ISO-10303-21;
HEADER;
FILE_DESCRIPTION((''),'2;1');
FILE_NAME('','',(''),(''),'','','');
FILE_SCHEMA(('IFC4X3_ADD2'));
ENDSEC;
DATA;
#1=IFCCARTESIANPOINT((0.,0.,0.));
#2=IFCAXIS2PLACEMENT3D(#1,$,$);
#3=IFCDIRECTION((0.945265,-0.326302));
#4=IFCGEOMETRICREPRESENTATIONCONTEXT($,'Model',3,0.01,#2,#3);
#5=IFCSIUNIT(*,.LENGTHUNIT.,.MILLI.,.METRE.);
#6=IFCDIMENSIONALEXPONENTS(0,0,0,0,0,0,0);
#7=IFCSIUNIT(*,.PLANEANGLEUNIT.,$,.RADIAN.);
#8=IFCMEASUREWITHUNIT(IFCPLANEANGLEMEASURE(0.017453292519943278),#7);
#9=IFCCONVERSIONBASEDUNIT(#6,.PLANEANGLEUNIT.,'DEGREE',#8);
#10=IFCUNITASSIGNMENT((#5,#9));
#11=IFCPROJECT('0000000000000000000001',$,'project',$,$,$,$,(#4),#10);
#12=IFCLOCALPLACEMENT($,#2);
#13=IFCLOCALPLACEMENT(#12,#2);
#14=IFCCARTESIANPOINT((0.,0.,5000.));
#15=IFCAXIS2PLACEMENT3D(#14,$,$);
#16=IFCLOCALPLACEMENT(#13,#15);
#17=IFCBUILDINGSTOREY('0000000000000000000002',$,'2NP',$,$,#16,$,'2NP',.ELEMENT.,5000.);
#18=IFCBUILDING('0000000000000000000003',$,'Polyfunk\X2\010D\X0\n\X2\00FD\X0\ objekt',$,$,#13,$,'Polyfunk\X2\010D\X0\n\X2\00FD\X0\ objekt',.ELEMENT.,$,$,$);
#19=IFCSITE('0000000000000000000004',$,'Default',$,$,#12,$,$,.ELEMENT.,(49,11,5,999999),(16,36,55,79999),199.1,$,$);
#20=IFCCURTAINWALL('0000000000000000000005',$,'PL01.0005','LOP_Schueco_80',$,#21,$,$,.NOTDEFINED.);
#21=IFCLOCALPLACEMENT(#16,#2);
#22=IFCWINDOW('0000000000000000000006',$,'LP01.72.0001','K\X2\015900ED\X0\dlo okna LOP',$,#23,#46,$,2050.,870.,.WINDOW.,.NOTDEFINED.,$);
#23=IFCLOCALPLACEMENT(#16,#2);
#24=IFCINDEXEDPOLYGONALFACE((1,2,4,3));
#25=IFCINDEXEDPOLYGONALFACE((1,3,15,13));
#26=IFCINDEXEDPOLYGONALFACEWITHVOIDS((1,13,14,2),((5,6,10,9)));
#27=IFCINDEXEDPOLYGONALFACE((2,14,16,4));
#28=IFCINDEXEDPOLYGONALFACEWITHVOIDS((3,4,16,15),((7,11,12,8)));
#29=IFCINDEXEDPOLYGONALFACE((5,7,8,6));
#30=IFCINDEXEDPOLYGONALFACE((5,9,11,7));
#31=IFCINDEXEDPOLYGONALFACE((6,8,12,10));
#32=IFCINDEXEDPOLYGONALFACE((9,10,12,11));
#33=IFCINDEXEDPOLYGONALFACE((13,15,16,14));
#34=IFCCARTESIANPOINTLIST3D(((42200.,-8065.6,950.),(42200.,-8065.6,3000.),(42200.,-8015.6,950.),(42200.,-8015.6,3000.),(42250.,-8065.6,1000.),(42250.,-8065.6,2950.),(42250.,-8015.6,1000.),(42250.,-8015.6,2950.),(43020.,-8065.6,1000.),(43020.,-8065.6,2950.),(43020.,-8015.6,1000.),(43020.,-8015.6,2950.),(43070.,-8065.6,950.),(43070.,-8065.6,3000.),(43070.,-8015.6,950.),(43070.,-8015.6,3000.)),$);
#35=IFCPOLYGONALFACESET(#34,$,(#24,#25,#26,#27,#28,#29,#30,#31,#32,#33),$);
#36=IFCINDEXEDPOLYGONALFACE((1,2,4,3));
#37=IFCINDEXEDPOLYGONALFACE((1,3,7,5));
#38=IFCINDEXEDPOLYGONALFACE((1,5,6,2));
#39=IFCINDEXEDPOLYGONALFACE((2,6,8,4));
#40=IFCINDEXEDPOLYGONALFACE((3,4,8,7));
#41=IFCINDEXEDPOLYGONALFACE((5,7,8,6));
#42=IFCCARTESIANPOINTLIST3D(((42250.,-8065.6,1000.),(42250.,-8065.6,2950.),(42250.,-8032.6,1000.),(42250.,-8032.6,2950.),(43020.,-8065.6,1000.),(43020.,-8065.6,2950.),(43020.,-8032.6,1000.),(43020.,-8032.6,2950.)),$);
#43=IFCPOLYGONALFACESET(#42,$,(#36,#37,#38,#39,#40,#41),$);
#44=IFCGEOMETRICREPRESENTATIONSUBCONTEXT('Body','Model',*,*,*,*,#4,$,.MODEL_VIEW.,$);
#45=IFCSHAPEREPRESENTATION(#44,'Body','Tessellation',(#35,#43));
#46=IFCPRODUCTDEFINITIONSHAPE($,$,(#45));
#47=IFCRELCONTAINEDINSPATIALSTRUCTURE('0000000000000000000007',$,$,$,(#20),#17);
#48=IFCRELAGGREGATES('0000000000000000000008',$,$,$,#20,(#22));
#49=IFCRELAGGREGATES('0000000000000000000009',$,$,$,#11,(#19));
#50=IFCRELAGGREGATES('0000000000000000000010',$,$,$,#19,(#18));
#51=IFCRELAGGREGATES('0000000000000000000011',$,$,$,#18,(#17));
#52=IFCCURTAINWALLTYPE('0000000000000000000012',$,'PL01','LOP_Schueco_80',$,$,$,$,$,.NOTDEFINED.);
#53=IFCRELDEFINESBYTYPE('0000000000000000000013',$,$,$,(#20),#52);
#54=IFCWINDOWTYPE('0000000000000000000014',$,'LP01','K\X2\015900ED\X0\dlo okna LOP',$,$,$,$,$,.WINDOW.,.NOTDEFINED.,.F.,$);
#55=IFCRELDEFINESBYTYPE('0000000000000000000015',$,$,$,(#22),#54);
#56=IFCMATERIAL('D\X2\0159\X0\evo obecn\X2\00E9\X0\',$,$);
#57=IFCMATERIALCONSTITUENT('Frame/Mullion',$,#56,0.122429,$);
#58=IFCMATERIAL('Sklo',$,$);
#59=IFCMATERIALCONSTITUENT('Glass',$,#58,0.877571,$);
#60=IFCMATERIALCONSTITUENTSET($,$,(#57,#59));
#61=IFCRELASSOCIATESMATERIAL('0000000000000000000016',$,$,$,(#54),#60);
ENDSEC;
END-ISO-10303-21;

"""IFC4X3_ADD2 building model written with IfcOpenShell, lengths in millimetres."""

from ifc_helpers import new_model, entity, si_unit, converted_unit, direction, frame, frame_2d, origin, place, context, subcontext, project, spatial, polyline, rectangle, outline, extrude, source, transform, mapped, material, constituent, constituent_set, type_object, type_shapes, element, aggregate, save


model = new_model("IFC4X3_ADD2")

# Units and contexts
model_context = context("Model", 3, precision=0.01, world=origin(), true_north=direction((0.945265, -0.326302)))
body_context = subcontext(model_context, "Body", "Model", "MODEL_VIEW")
ifc_project = project(units=[si_unit("LENGTHUNIT", "METRE", prefix="MILLI"), converted_unit("PLANEANGLEUNIT", "DEGREE", entity("IfcPlaneAngleMeasure", 0.017453292519943278), si_unit("PLANEANGLEUNIT", "RADIAN"), dimensions=[0, 0, 0, 0, 0, 0, 0])], contexts=[model_context])

# Site, building, storey
site_placement = place(None, origin())
site = spatial("IfcSite", under=ifc_project, at=site_placement, Name="Default", CompositionType="ELEMENT", RefLatitude=(49, 11, 5, 999999), RefLongitude=(16, 36, 55, 79999), RefElevation=199.1)
building_placement = place(site_placement, origin())
building = spatial("IfcBuilding", under=site, at=building_placement, Name="Polyfunkčný objekt", LongName="Polyfunkčný objekt", CompositionType="ELEMENT")
storey_placement = place(building_placement, frame((0.0, 0.0, 5000.0)))
storey = spatial("IfcBuildingStorey", under=building, at=storey_placement, Name="2NP", LongName="2NP", CompositionType="ELEMENT", Elevation=5000.0)

# Curtain wall
curtain_wall_type = type_object("IfcCurtainWallType", Name="PL01", Description="LOP_Schueco_80", PredefinedType="NOTDEFINED")
curtain_wall_placement = place(storey_placement, frame((0.0, 0.0, -5000.0)))
curtain_wall = element("IfcCurtainWall", 1, at=curtain_wall_placement, inside=storey, type_object=curtain_wall_type, Name="PL01.0005", Description="LOP_Schueco_80", PredefinedType="NOTDEFINED")
ifc_material_1 = material(Name="Sklo")

# Window
ifc_material_2 = material(Name="Dřevo obecné")
ifc_constituent_1 = constituent(ifc_material_2, Name="Frame/Mullion", fraction=0.122429)
ifc_constituent_2 = constituent(ifc_material_1, Name="Glass", fraction=0.877571)
ifc_constituent_set = constituent_set(constituents=[ifc_constituent_1, ifc_constituent_2])
window_type = type_object("IfcWindowType", Name="LP01", Description="Křídlo okna LOP", ParameterTakesPrecedence=False, PartitioningType="NOTDEFINED", PredefinedType="WINDOW", material=ifc_constituent_set)
shared_shape_1 = source(origin(), body_context, "Body", "SweptSolid", [
    extrude(outline(polyline([(-1025.0, -435.0), (1025.0, -435.0), (1025.0, 435.0), (-1025.0, 435.0), (-1025.0, -435.0)]), holes=[polyline([(-975.0, -385.0), (-975.0, 385.0), (975.0, 385.0), (975.0, -385.0), (-975.0, -385.0)])]), frame((0.0, 50.0, 1025.0), z_axis=(0.0, -1.0, 0.0), x_axis=(0.0, 0.0, -1.0)), (0.0, 0.0, 1.0), 50.0),
    extrude(rectangle(XDim=770.0, YDim=33.0, at=frame_2d((0.0, 0.0), x_axis=(1.0, 0.0))), frame((0.0, 33.5, 50.0), z_axis=(0.0, 0.0, 1.0), x_axis=(-1.0, 0.0, 0.0)), (0.0, 0.0, 1.0), 1950.0),
])
type_shapes(window_type, [shared_shape_1])
window_placement = place(curtain_wall_placement, frame((42635.0, -8015.6, 5950.0), z_axis=(0.0, 0.0, 1.0), x_axis=(-1.0, 0.0, 0.0)))
window = element("IfcWindow", 2, at=window_placement, type_object=window_type, Name="LP01.72.0001", Description="Křídlo okna LOP", OverallHeight=2050.0, OverallWidth=870.0, PartitioningType="NOTDEFINED", PredefinedType="WINDOW", context=body_context, shape_type="MappedRepresentation", body=[
    mapped(shared_shape_1, transform((0.0, 0.0, 0.0), scale=1.0)),
])
aggregate(curtain_wall, [window])

save(model, "model.ifc")
